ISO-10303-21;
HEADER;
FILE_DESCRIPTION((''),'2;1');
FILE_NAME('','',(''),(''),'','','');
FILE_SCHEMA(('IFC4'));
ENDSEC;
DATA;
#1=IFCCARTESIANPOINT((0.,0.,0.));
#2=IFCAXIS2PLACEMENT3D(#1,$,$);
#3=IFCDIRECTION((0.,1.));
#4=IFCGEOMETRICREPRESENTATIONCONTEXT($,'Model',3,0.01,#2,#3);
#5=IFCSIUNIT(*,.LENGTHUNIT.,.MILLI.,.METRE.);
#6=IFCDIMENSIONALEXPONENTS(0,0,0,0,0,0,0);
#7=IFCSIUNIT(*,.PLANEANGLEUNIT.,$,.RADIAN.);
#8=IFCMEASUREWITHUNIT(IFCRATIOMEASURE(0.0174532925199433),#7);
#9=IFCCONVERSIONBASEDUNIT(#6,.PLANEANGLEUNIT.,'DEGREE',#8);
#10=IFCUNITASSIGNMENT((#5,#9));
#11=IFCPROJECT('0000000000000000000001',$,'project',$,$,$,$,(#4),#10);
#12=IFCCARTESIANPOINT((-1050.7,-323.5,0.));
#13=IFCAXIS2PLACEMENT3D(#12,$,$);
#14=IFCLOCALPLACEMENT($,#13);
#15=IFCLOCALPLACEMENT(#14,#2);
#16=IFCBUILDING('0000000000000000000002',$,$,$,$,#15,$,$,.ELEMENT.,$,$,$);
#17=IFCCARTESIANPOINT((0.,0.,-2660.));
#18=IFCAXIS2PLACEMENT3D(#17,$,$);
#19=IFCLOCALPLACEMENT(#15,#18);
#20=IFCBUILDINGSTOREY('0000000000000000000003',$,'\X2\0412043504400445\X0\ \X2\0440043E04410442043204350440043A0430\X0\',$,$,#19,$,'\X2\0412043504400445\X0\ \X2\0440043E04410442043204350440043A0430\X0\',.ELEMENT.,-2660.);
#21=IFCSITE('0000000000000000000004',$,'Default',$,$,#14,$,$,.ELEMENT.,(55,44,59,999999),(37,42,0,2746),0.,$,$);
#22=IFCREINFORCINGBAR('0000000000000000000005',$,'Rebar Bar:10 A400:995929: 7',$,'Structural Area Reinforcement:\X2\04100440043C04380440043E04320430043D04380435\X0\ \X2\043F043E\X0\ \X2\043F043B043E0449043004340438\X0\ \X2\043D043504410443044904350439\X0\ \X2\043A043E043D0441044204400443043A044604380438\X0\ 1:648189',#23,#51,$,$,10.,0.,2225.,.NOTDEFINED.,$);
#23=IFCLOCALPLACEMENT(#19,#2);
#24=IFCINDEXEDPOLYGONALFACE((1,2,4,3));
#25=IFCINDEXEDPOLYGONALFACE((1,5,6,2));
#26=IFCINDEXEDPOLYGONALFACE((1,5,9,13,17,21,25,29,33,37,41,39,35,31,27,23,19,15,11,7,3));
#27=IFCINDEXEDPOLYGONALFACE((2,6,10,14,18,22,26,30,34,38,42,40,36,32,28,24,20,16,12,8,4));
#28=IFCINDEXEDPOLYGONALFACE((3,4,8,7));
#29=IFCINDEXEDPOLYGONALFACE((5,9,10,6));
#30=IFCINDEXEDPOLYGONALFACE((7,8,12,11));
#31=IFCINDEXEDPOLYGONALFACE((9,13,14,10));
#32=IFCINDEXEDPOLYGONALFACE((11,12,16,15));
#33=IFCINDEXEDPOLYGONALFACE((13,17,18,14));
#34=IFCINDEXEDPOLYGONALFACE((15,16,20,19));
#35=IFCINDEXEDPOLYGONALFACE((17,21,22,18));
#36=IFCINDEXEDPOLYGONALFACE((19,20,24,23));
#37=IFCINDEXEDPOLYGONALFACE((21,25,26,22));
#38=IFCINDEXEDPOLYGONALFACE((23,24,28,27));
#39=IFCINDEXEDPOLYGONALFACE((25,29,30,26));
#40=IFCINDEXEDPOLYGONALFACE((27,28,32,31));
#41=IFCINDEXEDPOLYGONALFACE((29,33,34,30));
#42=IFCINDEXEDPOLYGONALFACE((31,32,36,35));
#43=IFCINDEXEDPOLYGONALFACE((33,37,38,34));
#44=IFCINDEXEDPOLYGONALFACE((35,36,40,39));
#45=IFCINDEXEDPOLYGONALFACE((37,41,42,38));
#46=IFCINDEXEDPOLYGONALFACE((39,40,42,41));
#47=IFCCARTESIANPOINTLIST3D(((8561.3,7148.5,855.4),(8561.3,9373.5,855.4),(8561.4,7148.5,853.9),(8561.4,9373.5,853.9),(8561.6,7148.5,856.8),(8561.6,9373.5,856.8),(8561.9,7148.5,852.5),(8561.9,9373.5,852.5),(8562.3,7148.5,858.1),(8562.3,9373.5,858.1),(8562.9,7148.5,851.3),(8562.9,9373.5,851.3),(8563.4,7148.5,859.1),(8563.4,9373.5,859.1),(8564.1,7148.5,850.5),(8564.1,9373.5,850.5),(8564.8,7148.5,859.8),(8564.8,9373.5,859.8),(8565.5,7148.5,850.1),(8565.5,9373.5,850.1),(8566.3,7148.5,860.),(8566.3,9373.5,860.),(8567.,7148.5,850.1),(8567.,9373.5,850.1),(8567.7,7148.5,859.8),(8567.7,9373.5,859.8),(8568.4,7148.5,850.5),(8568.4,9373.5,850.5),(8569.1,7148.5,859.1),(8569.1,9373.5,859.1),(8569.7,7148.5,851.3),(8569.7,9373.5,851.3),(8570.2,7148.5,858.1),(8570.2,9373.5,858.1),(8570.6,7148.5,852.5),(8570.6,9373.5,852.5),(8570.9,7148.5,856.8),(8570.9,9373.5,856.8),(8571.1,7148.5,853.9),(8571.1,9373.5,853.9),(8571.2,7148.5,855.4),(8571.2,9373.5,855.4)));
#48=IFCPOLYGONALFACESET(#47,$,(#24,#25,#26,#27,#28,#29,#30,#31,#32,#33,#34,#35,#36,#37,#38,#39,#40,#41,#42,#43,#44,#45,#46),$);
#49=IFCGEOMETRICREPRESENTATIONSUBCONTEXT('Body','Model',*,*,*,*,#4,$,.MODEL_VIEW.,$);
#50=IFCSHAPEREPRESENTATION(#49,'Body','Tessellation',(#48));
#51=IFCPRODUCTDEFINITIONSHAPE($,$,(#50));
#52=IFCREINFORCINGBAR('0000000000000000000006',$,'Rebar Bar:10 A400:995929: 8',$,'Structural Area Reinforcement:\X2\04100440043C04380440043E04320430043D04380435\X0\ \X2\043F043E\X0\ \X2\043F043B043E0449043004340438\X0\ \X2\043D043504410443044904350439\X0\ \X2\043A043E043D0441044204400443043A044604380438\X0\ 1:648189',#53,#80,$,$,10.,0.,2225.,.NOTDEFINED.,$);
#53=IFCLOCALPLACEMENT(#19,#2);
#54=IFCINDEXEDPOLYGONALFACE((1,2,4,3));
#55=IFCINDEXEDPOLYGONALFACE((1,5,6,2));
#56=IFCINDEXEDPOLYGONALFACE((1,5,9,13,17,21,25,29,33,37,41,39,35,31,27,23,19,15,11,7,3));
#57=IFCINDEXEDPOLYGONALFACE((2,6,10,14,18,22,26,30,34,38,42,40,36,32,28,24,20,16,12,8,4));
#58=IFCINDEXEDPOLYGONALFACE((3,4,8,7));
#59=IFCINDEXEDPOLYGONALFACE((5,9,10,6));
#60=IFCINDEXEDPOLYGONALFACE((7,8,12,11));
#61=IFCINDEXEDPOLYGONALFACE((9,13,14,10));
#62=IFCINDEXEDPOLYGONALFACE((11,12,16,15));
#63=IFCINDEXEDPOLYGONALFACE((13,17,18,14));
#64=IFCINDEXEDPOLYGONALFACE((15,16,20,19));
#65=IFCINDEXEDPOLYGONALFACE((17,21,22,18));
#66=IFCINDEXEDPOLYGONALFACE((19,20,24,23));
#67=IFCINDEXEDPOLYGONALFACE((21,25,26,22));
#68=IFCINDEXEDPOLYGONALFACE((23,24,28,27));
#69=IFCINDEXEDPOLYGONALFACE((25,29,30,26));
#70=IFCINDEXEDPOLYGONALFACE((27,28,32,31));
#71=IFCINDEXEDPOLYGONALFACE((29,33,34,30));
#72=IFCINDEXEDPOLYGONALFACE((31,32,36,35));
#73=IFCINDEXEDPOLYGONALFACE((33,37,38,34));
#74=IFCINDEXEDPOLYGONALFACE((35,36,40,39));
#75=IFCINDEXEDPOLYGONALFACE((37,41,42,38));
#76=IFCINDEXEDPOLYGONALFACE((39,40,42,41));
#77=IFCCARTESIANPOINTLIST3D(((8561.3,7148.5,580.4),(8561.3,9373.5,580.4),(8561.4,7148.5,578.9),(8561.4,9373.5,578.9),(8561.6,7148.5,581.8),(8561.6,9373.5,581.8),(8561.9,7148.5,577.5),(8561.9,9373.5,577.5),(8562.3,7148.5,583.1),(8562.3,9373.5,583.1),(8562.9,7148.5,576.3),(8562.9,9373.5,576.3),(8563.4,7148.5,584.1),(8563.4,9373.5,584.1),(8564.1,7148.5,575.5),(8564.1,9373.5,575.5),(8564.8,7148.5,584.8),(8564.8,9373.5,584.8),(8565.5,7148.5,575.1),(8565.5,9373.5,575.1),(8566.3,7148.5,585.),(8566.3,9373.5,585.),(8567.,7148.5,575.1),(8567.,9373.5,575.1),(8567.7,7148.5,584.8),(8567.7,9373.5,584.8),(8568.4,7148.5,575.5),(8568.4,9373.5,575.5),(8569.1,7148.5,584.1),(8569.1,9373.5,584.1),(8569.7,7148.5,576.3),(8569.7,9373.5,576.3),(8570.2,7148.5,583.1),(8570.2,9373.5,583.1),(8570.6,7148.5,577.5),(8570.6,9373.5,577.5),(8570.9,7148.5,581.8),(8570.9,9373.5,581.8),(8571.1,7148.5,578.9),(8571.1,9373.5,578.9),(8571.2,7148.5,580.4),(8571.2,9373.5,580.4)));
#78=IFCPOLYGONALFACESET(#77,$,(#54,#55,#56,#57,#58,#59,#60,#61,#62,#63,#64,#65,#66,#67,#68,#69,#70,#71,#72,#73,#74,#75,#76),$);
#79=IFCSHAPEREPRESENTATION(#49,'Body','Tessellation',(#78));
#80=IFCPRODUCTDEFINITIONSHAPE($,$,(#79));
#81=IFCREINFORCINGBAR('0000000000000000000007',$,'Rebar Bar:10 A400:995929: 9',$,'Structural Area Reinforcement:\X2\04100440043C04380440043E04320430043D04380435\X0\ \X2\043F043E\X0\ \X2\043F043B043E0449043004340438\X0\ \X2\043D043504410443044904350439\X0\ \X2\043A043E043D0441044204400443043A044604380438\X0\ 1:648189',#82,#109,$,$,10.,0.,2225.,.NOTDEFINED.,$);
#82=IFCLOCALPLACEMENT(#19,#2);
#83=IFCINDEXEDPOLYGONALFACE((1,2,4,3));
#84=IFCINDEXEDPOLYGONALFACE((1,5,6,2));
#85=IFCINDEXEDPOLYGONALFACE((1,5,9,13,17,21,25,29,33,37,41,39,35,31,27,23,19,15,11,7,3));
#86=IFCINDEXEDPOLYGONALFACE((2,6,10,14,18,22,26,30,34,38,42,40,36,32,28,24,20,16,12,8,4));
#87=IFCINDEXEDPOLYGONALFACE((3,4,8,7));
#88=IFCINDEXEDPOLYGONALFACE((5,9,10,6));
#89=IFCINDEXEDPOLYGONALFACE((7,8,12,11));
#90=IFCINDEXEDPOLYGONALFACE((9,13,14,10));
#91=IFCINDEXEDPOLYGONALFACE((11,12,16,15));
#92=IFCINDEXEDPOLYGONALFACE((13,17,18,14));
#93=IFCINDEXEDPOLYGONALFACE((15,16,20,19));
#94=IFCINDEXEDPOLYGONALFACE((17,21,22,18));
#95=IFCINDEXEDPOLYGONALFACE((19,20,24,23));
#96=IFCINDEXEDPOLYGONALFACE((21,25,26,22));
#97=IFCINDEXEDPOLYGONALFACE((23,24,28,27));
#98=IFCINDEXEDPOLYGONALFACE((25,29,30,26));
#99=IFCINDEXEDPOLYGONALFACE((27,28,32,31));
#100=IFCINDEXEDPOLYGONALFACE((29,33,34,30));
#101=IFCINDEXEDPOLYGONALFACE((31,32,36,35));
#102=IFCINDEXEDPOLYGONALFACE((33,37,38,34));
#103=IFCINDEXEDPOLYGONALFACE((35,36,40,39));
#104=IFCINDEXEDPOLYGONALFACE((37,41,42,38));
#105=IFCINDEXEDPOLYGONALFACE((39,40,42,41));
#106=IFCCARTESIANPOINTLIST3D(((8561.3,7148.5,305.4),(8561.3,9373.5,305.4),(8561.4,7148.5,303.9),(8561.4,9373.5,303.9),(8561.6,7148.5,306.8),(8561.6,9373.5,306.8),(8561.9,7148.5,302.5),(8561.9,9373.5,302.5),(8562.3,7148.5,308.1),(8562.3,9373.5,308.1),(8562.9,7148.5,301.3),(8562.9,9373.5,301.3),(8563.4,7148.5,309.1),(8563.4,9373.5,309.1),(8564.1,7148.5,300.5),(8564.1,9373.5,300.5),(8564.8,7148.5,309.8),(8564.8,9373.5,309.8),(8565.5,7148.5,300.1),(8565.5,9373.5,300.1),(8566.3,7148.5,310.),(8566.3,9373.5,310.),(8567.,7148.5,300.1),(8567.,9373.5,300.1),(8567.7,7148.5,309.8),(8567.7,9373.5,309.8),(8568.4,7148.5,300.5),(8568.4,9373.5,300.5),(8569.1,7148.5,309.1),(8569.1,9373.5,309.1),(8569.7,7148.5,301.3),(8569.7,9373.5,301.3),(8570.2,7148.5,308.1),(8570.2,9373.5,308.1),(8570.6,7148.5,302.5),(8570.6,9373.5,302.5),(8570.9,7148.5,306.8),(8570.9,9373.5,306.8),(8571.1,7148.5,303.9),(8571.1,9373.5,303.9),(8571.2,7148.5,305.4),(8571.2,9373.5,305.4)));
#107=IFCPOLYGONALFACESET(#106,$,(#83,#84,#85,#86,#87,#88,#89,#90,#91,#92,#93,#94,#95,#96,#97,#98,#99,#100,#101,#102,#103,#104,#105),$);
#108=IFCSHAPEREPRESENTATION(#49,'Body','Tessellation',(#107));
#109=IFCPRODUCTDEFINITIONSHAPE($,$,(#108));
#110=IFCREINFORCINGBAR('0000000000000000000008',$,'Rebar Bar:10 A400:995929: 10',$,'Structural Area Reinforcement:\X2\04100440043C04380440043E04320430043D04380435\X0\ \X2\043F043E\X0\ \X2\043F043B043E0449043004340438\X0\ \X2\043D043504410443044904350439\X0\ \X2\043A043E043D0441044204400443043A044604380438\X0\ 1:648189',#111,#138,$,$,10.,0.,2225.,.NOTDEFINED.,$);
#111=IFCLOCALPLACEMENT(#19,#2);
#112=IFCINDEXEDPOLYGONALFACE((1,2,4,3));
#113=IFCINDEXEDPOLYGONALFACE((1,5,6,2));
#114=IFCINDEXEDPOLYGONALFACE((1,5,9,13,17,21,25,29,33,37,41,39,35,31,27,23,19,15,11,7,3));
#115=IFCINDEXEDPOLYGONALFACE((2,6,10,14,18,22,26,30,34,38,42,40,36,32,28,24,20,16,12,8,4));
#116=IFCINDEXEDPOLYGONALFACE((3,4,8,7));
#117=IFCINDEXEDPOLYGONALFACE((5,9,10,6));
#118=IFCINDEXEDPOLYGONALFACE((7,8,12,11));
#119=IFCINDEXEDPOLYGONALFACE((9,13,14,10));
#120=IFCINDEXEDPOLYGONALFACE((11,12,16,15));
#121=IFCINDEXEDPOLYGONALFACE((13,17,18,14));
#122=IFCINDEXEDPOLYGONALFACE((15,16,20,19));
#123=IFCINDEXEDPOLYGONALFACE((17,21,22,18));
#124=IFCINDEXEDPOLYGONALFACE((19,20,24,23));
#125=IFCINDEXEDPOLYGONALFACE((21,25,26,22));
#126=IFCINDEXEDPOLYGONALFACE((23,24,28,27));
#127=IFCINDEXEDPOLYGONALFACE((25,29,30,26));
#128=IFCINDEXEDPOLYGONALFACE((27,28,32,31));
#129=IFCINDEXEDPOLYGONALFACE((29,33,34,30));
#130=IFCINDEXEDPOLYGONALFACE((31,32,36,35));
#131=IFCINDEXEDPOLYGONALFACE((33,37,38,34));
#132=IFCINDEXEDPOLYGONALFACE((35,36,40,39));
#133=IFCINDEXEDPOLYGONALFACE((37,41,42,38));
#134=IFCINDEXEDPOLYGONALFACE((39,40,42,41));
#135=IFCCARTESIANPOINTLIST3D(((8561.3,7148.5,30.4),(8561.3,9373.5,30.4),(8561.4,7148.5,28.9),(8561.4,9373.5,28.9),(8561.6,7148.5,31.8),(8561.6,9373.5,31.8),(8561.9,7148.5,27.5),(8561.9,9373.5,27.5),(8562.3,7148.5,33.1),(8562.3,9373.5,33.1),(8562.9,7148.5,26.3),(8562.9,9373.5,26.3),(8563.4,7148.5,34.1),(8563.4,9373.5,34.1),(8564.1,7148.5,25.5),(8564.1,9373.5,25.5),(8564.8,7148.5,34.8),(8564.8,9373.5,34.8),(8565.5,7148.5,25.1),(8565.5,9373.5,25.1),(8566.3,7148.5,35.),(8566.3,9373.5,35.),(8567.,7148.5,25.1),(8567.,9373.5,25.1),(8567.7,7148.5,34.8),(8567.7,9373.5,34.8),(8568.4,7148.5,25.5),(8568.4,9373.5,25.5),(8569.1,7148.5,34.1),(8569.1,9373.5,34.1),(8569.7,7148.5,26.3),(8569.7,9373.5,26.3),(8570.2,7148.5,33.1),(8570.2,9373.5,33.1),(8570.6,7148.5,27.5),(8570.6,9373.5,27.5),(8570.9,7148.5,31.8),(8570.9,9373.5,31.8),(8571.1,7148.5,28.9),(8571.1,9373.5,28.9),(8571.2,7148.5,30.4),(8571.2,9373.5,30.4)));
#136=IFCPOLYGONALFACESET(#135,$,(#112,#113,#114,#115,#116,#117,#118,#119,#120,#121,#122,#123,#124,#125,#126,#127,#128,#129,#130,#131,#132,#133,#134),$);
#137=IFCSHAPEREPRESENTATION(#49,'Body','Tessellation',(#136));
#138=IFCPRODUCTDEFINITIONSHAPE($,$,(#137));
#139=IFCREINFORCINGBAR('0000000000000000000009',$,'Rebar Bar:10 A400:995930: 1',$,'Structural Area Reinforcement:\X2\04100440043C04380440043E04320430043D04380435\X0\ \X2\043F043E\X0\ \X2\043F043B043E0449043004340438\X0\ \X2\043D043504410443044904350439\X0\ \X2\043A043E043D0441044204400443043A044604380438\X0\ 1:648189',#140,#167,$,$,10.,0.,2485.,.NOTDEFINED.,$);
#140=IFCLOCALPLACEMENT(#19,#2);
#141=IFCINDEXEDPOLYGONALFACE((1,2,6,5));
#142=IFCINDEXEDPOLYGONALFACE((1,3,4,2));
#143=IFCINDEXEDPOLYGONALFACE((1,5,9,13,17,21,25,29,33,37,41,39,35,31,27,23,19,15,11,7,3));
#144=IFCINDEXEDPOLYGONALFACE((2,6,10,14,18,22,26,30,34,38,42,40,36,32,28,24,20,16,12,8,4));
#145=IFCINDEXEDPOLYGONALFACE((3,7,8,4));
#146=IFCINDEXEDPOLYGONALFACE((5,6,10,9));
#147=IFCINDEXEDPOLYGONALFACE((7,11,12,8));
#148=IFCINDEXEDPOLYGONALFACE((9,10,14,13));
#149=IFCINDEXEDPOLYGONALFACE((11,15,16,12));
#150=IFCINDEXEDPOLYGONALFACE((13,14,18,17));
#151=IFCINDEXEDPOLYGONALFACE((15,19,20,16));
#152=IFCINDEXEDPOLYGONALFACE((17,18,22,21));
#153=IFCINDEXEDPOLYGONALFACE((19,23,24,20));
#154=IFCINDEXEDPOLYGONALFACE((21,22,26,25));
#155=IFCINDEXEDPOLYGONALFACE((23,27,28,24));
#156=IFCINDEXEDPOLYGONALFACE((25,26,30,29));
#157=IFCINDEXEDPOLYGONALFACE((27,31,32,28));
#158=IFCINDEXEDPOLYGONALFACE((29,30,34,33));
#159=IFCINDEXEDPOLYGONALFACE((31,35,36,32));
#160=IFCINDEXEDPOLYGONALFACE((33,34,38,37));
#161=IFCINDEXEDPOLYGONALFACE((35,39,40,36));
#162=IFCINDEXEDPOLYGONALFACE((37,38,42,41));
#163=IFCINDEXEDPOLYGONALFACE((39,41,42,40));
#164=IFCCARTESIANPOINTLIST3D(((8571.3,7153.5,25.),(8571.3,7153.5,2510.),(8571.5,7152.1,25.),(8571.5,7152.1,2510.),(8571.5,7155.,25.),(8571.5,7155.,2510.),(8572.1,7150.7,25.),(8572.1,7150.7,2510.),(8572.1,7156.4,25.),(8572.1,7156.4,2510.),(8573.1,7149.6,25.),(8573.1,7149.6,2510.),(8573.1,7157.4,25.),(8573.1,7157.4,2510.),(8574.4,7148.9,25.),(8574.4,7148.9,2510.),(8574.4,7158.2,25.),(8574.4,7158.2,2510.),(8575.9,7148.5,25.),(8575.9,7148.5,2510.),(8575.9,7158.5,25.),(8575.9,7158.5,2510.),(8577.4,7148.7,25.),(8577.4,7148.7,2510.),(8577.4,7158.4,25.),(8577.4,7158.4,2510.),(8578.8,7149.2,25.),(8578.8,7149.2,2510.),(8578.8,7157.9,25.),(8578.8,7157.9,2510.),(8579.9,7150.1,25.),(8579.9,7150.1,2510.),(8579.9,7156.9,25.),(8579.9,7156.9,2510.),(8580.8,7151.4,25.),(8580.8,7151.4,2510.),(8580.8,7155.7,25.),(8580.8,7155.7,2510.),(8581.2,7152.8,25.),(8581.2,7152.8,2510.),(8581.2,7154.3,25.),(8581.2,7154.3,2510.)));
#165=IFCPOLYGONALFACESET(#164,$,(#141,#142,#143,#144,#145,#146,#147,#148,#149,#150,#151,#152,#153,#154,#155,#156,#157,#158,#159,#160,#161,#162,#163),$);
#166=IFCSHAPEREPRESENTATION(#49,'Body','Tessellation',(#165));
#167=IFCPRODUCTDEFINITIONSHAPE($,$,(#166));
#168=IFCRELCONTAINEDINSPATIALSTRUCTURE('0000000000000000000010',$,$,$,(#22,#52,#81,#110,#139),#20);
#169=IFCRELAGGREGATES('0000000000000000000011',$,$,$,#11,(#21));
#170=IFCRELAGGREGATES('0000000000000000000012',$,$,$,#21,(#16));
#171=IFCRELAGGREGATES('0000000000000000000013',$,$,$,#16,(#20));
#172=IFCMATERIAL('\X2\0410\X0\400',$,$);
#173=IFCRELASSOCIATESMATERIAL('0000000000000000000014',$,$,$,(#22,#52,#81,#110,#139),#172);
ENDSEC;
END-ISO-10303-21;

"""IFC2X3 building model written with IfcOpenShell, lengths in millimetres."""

from ifc_helpers import new_model, entity, si_unit, converted_unit, direction, frame, origin, place, context, subcontext, project, spatial, material, element, save


model = new_model("IFC2X3")

# Units and contexts
model_context = context("Model", 3, precision=0.01, world=origin(), true_north=direction((0.0, 1.0)))
body_context = subcontext(model_context, "Body", "Model", "MODEL_VIEW")
ifc_project = project(units=[si_unit("LENGTHUNIT", "METRE", prefix="MILLI"), converted_unit("PLANEANGLEUNIT", "DEGREE", entity("IfcRatioMeasure", 0.0174532925199433), si_unit("PLANEANGLEUNIT", "RADIAN"), dimensions=[0, 0, 0, 0, 0, 0, 0])], contexts=[model_context])

# Site, building, storey
site_placement = place(None, frame((-1050.7, -323.5, 0.0)))
site = spatial("IfcSite", under=ifc_project, at=site_placement, Name="Default", CompositionType="ELEMENT", RefLatitude=(55, 44, 59, 999999), RefLongitude=(37, 42, 0, 2746), RefElevation=0.0)
building_placement = place(site_placement, origin())
building = spatial("IfcBuilding", under=site, at=building_placement, CompositionType="ELEMENT")
storey_placement = place(building_placement, frame((0.0, 0.0, -2660.0)))
storey = spatial("IfcBuildingStorey", under=building, at=storey_placement, Name="Верх ростверка", LongName="Верх ростверка", CompositionType="ELEMENT", Elevation=-2660.0)

# Reinforcing bars
ifc_material = material(Name="А400")
reinforcing_bar_1_placement = place(storey_placement, origin())
element("IfcReinforcingBar", 1, at=reinforcing_bar_1_placement, inside=storey, material=ifc_material, Name="Rebar Bar:10 A400:995929: 7", ObjectType="Structural Area Reinforcement:Армирование по площади несущей конструкции 1:648189", BarLength=2225.0, BarRole="NOTDEFINED", CrossSectionArea=0.0, NominalDiameter=10.0, context=body_context, shape_type="AdvancedSweptSolid", body=[
    entity("IfcSweptDiskSolid", entity("IfcCompositeCurve", [entity("IfcCompositeCurveSegment", "CONTINUOUS", True, entity("IfcPolyline", [entity("IfcCartesianPoint", [8566.3, 7148.5, 855.0]), entity("IfcCartesianPoint", [8566.3, 9373.5, 855.0])]))], False), 5.0, None, 0.0, 1.0),
])
reinforcing_bar_2_placement = place(storey_placement, origin())
element("IfcReinforcingBar", 2, at=reinforcing_bar_2_placement, inside=storey, material=ifc_material, Name="Rebar Bar:10 A400:995929: 8", ObjectType="Structural Area Reinforcement:Армирование по площади несущей конструкции 1:648189", BarLength=2225.0, BarRole="NOTDEFINED", CrossSectionArea=0.0, NominalDiameter=10.0, context=body_context, shape_type="AdvancedSweptSolid", body=[
    entity("IfcSweptDiskSolid", entity("IfcCompositeCurve", [entity("IfcCompositeCurveSegment", "CONTINUOUS", True, entity("IfcPolyline", [entity("IfcCartesianPoint", [8566.3, 7148.5, 580.0]), entity("IfcCartesianPoint", [8566.3, 9373.5, 580.0])]))], False), 5.0, None, 0.0, 1.0),
])
reinforcing_bar_3_placement = place(storey_placement, origin())
element("IfcReinforcingBar", 3, at=reinforcing_bar_3_placement, inside=storey, material=ifc_material, Name="Rebar Bar:10 A400:995929: 9", ObjectType="Structural Area Reinforcement:Армирование по площади несущей конструкции 1:648189", BarLength=2225.0, BarRole="NOTDEFINED", CrossSectionArea=0.0, NominalDiameter=10.0, context=body_context, shape_type="AdvancedSweptSolid", body=[
    entity("IfcSweptDiskSolid", entity("IfcCompositeCurve", [entity("IfcCompositeCurveSegment", "CONTINUOUS", True, entity("IfcPolyline", [entity("IfcCartesianPoint", [8566.3, 7148.5, 305.0]), entity("IfcCartesianPoint", [8566.3, 9373.5, 305.0])]))], False), 5.0, None, 0.0, 1.0),
])
reinforcing_bar_4_placement = place(storey_placement, origin())
element("IfcReinforcingBar", 4, at=reinforcing_bar_4_placement, inside=storey, material=ifc_material, Name="Rebar Bar:10 A400:995929: 10", ObjectType="Structural Area Reinforcement:Армирование по площади несущей конструкции 1:648189", BarLength=2225.0, BarRole="NOTDEFINED", CrossSectionArea=0.0, NominalDiameter=10.0, context=body_context, shape_type="AdvancedSweptSolid", body=[
    entity("IfcSweptDiskSolid", entity("IfcCompositeCurve", [entity("IfcCompositeCurveSegment", "CONTINUOUS", True, entity("IfcPolyline", [entity("IfcCartesianPoint", [8566.3, 7148.5, 30.0]), entity("IfcCartesianPoint", [8566.3, 9373.5, 30.0])]))], False), 5.0, None, 0.0, 1.0),
])
reinforcing_bar_5_placement = place(storey_placement, origin())
element("IfcReinforcingBar", 5, at=reinforcing_bar_5_placement, inside=storey, material=ifc_material, Name="Rebar Bar:10 A400:995930: 1", ObjectType="Structural Area Reinforcement:Армирование по площади несущей конструкции 1:648189", BarLength=2485.0, BarRole="NOTDEFINED", CrossSectionArea=0.0, NominalDiameter=10.0, context=body_context, shape_type="AdvancedSweptSolid", body=[
    entity("IfcSweptDiskSolid", entity("IfcCompositeCurve", [entity("IfcCompositeCurveSegment", "CONTINUOUS", True, entity("IfcPolyline", [entity("IfcCartesianPoint", [8576.3, 7153.5, 2510.0]), entity("IfcCartesianPoint", [8576.3, 7153.5, 25.0])]))], False), 5.0, None, 0.0, 1.0),
])

save(model, "model.ifc")
